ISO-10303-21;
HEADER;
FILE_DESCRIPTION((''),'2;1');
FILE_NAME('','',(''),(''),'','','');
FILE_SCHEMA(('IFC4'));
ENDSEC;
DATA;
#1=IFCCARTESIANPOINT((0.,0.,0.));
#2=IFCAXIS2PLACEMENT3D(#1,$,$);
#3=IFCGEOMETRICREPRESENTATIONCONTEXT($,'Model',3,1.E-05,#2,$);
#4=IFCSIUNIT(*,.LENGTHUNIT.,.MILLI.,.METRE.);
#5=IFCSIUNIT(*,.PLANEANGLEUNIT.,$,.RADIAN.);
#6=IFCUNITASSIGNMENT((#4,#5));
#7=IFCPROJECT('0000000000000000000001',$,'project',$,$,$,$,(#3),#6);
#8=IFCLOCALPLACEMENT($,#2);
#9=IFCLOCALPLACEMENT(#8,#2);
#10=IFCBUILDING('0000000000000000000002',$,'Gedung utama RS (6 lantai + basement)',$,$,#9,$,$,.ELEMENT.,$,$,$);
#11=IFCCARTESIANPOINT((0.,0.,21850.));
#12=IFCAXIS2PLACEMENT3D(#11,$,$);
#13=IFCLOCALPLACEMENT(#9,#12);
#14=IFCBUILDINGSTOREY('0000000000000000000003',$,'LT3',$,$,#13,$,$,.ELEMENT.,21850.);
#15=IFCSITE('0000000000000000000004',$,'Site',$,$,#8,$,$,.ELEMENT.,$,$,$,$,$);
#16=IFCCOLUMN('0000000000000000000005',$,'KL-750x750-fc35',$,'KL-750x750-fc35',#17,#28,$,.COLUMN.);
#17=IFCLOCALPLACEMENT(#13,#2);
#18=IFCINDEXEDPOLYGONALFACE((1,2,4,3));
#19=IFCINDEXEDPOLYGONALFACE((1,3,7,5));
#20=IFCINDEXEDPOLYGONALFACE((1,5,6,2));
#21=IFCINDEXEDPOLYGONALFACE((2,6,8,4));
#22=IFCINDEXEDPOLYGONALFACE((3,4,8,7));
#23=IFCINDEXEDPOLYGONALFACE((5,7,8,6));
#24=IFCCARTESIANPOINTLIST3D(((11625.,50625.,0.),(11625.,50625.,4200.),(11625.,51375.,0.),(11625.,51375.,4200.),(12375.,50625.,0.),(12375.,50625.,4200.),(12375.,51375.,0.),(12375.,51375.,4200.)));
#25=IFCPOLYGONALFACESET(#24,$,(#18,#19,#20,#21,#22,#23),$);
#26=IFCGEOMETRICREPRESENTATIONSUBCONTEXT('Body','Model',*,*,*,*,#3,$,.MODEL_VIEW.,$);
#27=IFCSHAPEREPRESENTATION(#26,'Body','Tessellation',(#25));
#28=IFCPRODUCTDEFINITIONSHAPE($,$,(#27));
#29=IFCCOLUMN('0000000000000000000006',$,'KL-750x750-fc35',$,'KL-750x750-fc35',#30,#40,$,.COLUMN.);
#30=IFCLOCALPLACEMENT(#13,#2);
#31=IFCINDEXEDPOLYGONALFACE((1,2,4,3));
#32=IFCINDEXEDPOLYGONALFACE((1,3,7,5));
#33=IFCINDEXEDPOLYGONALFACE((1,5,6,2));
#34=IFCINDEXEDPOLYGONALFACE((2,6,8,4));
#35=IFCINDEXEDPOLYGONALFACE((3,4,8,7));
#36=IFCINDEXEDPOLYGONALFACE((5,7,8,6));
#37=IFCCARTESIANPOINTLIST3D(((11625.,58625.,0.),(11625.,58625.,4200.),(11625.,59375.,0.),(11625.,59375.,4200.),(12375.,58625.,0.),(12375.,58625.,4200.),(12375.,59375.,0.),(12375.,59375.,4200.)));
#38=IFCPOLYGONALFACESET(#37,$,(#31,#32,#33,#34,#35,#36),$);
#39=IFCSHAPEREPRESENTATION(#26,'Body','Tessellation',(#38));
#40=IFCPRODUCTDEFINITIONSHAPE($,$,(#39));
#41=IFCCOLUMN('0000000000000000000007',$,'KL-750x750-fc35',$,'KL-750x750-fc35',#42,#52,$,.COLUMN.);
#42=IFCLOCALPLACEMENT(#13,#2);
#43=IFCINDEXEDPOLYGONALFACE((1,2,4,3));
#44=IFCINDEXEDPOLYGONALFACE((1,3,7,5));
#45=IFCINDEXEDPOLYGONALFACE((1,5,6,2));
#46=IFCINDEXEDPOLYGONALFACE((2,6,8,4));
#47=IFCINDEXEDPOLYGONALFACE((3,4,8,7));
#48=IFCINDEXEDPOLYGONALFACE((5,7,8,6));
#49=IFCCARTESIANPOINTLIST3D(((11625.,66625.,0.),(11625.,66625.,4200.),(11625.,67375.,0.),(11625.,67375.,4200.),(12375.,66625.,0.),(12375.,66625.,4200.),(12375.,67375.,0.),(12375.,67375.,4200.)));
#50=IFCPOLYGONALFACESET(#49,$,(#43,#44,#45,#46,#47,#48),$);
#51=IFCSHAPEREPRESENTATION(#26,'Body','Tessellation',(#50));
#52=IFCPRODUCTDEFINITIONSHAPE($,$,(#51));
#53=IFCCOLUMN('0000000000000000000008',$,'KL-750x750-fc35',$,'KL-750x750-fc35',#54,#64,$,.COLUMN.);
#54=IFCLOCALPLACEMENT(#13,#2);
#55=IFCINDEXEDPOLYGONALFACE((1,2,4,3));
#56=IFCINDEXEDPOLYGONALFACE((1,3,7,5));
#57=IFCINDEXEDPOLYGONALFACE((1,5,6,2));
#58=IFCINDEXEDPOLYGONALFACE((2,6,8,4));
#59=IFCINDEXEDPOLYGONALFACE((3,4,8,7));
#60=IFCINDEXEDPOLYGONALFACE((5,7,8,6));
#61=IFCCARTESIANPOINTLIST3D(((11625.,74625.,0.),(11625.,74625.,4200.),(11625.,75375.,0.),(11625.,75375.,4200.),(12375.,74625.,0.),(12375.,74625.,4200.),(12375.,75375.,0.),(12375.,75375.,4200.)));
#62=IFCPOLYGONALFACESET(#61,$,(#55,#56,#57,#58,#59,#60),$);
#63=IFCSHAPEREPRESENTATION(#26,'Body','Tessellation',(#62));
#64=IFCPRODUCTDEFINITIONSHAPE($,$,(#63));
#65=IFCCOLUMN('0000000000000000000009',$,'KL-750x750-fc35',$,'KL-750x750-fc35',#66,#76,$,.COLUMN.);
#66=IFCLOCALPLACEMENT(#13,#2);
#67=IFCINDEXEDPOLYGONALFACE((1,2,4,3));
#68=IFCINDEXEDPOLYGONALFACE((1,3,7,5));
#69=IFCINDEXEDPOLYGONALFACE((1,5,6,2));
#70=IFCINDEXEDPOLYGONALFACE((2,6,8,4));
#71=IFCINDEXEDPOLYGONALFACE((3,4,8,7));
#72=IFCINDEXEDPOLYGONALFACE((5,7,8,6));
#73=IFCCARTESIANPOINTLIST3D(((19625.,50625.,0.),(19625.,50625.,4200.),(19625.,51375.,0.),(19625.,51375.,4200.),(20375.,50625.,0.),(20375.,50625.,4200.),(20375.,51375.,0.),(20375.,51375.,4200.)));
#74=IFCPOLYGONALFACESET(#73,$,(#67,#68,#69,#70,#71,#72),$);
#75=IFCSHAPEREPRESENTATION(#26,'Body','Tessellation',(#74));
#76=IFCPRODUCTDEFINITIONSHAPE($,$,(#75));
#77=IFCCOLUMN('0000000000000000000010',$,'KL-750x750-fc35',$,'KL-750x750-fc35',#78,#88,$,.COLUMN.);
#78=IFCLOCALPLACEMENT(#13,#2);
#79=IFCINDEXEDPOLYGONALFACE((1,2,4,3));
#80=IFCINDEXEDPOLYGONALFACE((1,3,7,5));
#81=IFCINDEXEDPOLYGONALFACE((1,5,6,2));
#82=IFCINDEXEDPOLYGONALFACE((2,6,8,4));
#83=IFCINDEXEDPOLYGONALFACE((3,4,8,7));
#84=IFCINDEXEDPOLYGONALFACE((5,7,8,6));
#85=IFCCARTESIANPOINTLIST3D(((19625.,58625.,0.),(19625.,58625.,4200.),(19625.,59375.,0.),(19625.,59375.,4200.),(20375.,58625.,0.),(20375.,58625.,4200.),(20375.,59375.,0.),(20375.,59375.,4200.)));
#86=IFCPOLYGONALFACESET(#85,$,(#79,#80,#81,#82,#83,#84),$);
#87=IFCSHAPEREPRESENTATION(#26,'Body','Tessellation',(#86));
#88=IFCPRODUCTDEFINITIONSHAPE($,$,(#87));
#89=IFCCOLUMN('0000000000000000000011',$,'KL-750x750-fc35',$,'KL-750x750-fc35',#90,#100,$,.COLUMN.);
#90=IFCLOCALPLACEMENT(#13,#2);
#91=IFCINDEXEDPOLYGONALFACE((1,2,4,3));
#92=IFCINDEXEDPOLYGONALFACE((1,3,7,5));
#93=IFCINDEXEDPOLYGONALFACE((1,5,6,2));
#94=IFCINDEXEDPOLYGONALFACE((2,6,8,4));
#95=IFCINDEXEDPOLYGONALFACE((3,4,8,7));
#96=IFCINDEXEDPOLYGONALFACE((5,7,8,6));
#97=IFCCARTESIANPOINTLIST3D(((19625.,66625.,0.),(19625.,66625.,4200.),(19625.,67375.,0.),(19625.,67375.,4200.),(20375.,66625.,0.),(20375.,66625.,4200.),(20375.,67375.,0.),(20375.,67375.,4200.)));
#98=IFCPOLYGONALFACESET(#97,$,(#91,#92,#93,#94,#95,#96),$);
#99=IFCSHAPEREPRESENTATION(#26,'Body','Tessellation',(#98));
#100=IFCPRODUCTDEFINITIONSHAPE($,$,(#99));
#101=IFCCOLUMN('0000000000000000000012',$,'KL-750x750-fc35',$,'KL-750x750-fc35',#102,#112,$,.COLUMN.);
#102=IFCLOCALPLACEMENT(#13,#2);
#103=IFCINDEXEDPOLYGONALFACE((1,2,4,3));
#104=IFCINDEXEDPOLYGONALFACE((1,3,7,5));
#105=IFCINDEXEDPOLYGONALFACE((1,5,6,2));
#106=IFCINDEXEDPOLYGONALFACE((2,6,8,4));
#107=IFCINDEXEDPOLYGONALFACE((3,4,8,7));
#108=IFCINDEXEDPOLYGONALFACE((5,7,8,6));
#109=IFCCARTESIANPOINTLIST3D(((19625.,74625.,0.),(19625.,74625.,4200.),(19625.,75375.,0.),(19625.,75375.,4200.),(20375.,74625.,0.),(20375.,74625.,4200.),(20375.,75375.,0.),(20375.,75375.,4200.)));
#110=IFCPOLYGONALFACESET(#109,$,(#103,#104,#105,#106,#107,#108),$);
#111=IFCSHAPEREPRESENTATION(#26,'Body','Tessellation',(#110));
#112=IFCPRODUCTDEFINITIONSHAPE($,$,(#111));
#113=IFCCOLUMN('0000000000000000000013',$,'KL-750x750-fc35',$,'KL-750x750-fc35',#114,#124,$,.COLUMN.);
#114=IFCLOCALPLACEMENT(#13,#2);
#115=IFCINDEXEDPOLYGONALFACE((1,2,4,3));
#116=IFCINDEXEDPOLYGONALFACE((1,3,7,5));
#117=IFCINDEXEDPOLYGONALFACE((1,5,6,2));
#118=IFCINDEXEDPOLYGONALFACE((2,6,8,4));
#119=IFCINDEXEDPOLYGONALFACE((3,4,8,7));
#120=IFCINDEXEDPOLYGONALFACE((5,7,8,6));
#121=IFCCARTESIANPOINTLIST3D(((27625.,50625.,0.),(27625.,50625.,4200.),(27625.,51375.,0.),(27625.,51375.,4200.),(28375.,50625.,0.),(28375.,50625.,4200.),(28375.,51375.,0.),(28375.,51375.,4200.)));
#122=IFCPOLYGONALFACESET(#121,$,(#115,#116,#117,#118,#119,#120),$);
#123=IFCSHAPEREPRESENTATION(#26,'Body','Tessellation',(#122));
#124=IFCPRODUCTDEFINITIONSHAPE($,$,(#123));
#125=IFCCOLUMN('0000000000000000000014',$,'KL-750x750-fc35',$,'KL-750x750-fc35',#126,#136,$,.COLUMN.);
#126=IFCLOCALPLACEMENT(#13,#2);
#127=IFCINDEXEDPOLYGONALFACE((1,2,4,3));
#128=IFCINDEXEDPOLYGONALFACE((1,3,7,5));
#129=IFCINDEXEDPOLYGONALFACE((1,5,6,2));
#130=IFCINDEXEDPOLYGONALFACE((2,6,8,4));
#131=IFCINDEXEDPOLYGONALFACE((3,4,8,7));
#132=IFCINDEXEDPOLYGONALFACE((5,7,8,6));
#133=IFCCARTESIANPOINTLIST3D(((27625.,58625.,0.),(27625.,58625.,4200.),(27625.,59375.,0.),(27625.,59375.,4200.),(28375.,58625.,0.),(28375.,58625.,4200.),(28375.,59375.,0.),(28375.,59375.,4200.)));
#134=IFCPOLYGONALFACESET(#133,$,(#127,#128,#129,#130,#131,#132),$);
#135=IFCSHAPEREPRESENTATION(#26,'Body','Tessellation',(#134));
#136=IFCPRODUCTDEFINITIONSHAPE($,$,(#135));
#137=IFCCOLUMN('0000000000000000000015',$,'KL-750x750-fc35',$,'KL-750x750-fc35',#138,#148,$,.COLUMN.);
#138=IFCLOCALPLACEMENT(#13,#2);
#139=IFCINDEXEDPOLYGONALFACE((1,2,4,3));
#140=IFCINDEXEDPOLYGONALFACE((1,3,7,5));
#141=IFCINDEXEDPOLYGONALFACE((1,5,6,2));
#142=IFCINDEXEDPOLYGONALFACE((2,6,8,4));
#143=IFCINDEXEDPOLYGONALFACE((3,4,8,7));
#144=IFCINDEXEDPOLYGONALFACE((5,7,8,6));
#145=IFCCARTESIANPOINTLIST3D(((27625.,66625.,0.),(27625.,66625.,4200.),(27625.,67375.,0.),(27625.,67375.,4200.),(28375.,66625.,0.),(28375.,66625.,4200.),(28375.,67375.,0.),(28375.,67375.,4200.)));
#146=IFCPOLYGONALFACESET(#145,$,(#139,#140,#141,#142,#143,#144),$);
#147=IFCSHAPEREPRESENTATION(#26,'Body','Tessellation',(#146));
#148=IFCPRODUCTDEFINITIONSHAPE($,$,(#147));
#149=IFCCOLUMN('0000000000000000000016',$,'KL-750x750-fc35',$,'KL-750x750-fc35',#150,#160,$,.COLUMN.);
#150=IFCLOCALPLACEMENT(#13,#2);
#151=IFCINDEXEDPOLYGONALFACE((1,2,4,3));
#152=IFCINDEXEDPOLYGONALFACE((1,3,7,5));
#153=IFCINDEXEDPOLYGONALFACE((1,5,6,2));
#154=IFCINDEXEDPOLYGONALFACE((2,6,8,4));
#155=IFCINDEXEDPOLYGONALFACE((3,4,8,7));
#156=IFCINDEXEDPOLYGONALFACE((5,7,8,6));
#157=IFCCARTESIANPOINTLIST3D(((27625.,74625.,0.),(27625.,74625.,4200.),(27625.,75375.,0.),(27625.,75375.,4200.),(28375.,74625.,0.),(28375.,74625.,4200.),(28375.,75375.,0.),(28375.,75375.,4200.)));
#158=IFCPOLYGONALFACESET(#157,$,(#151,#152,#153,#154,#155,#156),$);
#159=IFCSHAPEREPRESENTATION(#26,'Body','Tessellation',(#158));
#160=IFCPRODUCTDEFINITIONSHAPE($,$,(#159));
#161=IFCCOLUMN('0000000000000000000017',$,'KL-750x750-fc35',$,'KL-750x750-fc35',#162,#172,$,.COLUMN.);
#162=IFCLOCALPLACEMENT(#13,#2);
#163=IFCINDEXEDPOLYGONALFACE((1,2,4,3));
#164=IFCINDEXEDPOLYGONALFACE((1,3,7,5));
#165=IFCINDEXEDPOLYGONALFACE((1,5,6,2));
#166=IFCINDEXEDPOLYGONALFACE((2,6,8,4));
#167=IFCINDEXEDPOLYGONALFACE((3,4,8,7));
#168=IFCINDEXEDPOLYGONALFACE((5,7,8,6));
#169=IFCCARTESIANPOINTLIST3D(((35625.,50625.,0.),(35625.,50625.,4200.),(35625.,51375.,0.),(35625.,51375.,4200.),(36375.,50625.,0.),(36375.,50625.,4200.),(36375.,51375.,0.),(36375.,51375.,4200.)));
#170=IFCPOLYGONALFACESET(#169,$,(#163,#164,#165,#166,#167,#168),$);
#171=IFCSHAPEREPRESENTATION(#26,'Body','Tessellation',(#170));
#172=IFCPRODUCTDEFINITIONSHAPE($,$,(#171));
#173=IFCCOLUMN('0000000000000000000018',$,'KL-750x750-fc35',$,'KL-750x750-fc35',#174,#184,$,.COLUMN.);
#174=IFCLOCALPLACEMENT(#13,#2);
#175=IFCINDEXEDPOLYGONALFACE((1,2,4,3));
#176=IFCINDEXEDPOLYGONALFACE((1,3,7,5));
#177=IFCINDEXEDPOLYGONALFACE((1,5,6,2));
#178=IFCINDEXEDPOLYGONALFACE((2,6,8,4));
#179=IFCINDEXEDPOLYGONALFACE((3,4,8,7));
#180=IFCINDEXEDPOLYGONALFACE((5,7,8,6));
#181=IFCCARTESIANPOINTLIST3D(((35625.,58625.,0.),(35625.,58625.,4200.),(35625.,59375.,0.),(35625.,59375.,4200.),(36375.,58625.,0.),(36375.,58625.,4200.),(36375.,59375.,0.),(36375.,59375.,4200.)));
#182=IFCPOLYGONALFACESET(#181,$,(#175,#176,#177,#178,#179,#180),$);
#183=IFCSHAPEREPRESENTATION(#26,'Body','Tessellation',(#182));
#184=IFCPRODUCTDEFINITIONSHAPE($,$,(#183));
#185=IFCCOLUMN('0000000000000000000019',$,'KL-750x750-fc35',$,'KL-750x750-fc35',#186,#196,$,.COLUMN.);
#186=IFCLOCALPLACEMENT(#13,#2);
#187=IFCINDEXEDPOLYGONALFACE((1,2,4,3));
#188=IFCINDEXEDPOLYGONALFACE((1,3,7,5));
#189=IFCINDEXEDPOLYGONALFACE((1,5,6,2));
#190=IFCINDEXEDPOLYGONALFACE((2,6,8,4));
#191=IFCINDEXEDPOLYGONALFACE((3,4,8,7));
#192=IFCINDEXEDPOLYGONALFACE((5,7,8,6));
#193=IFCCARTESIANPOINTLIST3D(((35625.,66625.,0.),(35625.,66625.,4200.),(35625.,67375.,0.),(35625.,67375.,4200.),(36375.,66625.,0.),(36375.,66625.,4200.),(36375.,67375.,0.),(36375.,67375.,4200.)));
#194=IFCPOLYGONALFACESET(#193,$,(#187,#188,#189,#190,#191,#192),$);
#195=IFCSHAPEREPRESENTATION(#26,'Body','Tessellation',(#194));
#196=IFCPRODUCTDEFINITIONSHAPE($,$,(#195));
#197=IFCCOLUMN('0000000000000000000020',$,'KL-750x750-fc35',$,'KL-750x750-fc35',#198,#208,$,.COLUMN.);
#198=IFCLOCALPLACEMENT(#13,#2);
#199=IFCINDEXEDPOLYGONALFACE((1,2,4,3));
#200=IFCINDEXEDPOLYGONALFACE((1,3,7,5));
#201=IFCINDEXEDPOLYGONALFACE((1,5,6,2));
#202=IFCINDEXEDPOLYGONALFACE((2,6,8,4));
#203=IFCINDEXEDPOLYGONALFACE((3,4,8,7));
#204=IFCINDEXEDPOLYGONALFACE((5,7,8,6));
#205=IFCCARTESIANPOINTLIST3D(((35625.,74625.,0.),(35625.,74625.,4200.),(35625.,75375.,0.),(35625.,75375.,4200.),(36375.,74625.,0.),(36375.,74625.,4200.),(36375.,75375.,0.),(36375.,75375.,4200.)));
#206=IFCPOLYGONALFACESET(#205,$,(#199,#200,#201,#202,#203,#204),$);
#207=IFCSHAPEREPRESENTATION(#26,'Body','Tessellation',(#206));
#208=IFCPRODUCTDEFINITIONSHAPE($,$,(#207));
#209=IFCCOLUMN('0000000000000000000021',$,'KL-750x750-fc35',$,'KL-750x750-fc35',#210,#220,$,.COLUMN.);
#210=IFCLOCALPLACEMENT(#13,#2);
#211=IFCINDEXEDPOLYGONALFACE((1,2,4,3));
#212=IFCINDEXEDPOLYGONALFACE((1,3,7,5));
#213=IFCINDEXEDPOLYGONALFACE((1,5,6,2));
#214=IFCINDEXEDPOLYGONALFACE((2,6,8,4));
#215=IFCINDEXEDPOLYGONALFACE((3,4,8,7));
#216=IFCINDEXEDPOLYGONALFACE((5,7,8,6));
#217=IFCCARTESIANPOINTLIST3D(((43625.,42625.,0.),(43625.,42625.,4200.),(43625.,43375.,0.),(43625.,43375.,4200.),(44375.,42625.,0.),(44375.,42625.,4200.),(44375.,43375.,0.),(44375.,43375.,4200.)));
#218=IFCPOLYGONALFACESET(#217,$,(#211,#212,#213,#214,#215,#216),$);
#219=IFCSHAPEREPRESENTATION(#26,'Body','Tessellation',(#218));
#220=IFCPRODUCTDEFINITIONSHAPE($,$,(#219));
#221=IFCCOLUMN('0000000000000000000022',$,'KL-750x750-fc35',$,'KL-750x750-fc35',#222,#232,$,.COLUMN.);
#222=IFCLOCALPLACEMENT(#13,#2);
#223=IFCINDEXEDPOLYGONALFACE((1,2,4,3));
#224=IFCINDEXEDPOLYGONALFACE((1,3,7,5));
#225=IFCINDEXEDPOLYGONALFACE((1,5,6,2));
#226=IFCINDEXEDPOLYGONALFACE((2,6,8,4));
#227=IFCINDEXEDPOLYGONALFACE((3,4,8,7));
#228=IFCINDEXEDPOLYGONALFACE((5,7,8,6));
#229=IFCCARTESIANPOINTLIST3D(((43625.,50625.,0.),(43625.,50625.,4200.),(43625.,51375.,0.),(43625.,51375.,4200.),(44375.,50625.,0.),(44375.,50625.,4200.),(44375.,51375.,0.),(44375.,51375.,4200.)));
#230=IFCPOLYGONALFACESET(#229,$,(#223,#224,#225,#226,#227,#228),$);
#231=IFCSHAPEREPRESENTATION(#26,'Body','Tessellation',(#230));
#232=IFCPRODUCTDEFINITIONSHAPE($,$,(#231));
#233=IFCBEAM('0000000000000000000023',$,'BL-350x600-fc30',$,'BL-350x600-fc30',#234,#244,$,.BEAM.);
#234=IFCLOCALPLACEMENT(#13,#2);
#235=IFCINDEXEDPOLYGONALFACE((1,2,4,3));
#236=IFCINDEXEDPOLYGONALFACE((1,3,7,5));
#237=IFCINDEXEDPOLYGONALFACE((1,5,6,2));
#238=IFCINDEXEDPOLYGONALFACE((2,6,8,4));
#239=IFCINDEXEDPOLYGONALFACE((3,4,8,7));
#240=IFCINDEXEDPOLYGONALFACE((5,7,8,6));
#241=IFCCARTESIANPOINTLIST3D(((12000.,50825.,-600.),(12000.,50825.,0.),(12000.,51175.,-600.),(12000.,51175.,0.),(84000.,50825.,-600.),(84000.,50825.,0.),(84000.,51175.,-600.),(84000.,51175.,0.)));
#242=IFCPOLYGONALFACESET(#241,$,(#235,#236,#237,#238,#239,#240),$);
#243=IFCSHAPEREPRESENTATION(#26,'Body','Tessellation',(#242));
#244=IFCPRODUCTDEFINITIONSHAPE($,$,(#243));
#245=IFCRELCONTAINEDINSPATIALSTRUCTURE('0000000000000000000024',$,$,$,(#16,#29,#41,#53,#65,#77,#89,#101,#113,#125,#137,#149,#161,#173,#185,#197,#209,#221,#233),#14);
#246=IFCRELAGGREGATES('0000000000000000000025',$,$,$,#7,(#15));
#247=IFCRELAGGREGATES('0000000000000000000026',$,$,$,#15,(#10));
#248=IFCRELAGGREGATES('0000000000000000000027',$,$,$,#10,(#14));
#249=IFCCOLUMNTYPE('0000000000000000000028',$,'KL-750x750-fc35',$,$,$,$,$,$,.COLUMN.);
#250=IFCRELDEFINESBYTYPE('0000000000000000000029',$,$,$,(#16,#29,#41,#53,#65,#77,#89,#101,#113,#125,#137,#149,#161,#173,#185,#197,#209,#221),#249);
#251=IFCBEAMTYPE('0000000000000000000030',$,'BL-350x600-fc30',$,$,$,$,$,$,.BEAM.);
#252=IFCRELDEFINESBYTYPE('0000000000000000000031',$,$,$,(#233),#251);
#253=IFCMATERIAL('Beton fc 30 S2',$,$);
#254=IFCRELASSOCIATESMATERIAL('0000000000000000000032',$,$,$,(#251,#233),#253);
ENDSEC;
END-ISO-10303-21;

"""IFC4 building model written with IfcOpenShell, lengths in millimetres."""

from ifc_helpers import new_model, si_unit, frame, origin, origin_2d, place, context, subcontext, project, spatial, rectangle, extrude, material, material_profile, profile_set, profile_usage, type_object, element, save


model = new_model("IFC4")

# Units and contexts
model_context = context("Model", 3, precision=1e-05, world=origin())
body_context = subcontext(model_context, "Body", "Model", "MODEL_VIEW")
ifc_project = project(units=[si_unit("LENGTHUNIT", "METRE", prefix="MILLI"), si_unit("PLANEANGLEUNIT", "RADIAN")], contexts=[model_context])

# Site, building, storey
site_placement = place(None, origin())
site = spatial("IfcSite", under=ifc_project, at=site_placement, Name="Site", CompositionType="ELEMENT")
building_placement = place(site_placement, origin())
building = spatial("IfcBuilding", under=site, at=building_placement, Name="Gedung utama RS (6 lantai + basement)", CompositionType="ELEMENT")
storey_placement = place(building_placement, frame((0.0, 0.0, 21850.0)))
storey = spatial("IfcBuildingStorey", under=building, at=storey_placement, Name="LT3", CompositionType="ELEMENT", Elevation=21850.0)

# Columns
ifc_material_profile_1 = material_profile(None, rectangle(XDim=750.0, YDim=750.0, at=origin_2d()), Name="KL-750x750-fc35")
ifc_profile_set_1 = profile_set([ifc_material_profile_1], Name="KL-750x750-fc35")
ifc_profile_usage_1 = profile_usage(ifc_profile_set_1, cardinal=5)
column_type = type_object("IfcColumnType", Name="KL-750x750-fc35", PredefinedType="COLUMN", material=ifc_profile_set_1)
for number, where, z_axis, x_axis, name in (
    (1, (12000.0, 51000.0, 0.0), (0.0, 0.0, 1.0), (1.0, 0.0, 0.0), "KL-750x750-fc35"),
    (2, (12000.0, 59000.0, 0.0), (0.0, 0.0, 1.0), (1.0, 0.0, 0.0), "KL-750x750-fc35"),
    (3, (12000.0, 67000.0, 0.0), (0.0, 0.0, 1.0), (1.0, 0.0, 0.0), "KL-750x750-fc35"),
    (4, (12000.0, 75000.0, 0.0), (0.0, 0.0, 1.0), (1.0, 0.0, 0.0), "KL-750x750-fc35"),
    (5, (20000.0, 51000.0, 0.0), (0.0, 0.0, 1.0), (1.0, 0.0, 0.0), "KL-750x750-fc35"),
    (6, (20000.0, 59000.0, 0.0), (0.0, 0.0, 1.0), (1.0, 0.0, 0.0), "KL-750x750-fc35"),
    (7, (20000.0, 67000.0, 0.0), (0.0, 0.0, 1.0), (1.0, 0.0, 0.0), "KL-750x750-fc35"),
    (8, (20000.0, 75000.0, 0.0), (0.0, 0.0, 1.0), (1.0, 0.0, 0.0), "KL-750x750-fc35"),
    (9, (28000.0, 51000.0, 0.0), (0.0, 0.0, 1.0), (1.0, 0.0, 0.0), "KL-750x750-fc35"),
    (10, (28000.0, 59000.0, 0.0), (0.0, 0.0, 1.0), (1.0, 0.0, 0.0), "KL-750x750-fc35"),
    (11, (28000.0, 67000.0, 0.0), (0.0, 0.0, 1.0), (1.0, 0.0, 0.0), "KL-750x750-fc35"),
    (12, (28000.0, 75000.0, 0.0), (0.0, 0.0, 1.0), (1.0, 0.0, 0.0), "KL-750x750-fc35"),
    (13, (36000.0, 51000.0, 0.0), (0.0, 0.0, 1.0), (1.0, 0.0, 0.0), "KL-750x750-fc35"),
    (14, (36000.0, 59000.0, 0.0), (0.0, 0.0, 1.0), (1.0, 0.0, 0.0), "KL-750x750-fc35"),
    (15, (36000.0, 67000.0, 0.0), (0.0, 0.0, 1.0), (1.0, 0.0, 0.0), "KL-750x750-fc35"),
    (16, (36000.0, 75000.0, 0.0), (0.0, 0.0, 1.0), (1.0, 0.0, 0.0), "KL-750x750-fc35"),
    (17, (44000.0, 43000.0, 0.0), (0.0, 0.0, 1.0), (1.0, 0.0, 0.0), "KL-750x750-fc35"),
    (18, (44000.0, 51000.0, 0.0), (0.0, 0.0, 1.0), (1.0, 0.0, 0.0), "KL-750x750-fc35"),
):
    element("IfcColumn", number, at=place(storey_placement, frame(where, z_axis=z_axis, x_axis=x_axis)), inside=storey, type_object=column_type, material=ifc_profile_usage_1, Name=name, ObjectType="KL-750x750-fc35", PredefinedType="COLUMN", context=body_context, shape_type="SweptSolid", body=[
        extrude(rectangle(XDim=750.0, YDim=750.0, at=origin_2d()), origin(), (0.0, 0.0, 1.0), 4200.0),
    ])

# Beam
ifc_material = material(Name="Beton fc 30 S2")
ifc_material_profile_2 = material_profile(ifc_material, rectangle(XDim=350.0, YDim=600.0, at=origin_2d()), Name="BL-350x600-fc30")
ifc_profile_set_2 = profile_set([ifc_material_profile_2], Name="BL-350x600-fc30")
ifc_profile_usage_2 = profile_usage(ifc_profile_set_2, cardinal=8)
beam_type = type_object("IfcBeamType", Name="BL-350x600-fc30", PredefinedType="BEAM", material=ifc_profile_set_2)
for number, where, name in (
    (19, (12000.0, 51000.0, -300.0), "BL-350x600-fc30"),
):
    element("IfcBeam", number, at=place(storey_placement, frame(where)), inside=storey, type_object=beam_type, material=ifc_profile_usage_2, Name=name, ObjectType="BL-350x600-fc30", PredefinedType="BEAM", context=body_context, shape_type="SweptSolid", body=[
        extrude(rectangle(XDim=350.0, YDim=600.0, at=origin_2d()), frame((0.0, 0.0, 0.0), z_axis=(1.0, 0.0, 0.0), x_axis=(0.0, 1.0, 0.0)), (0.0, 0.0, 1.0), 72000.0),
    ])

save(model, "model.ifc")
